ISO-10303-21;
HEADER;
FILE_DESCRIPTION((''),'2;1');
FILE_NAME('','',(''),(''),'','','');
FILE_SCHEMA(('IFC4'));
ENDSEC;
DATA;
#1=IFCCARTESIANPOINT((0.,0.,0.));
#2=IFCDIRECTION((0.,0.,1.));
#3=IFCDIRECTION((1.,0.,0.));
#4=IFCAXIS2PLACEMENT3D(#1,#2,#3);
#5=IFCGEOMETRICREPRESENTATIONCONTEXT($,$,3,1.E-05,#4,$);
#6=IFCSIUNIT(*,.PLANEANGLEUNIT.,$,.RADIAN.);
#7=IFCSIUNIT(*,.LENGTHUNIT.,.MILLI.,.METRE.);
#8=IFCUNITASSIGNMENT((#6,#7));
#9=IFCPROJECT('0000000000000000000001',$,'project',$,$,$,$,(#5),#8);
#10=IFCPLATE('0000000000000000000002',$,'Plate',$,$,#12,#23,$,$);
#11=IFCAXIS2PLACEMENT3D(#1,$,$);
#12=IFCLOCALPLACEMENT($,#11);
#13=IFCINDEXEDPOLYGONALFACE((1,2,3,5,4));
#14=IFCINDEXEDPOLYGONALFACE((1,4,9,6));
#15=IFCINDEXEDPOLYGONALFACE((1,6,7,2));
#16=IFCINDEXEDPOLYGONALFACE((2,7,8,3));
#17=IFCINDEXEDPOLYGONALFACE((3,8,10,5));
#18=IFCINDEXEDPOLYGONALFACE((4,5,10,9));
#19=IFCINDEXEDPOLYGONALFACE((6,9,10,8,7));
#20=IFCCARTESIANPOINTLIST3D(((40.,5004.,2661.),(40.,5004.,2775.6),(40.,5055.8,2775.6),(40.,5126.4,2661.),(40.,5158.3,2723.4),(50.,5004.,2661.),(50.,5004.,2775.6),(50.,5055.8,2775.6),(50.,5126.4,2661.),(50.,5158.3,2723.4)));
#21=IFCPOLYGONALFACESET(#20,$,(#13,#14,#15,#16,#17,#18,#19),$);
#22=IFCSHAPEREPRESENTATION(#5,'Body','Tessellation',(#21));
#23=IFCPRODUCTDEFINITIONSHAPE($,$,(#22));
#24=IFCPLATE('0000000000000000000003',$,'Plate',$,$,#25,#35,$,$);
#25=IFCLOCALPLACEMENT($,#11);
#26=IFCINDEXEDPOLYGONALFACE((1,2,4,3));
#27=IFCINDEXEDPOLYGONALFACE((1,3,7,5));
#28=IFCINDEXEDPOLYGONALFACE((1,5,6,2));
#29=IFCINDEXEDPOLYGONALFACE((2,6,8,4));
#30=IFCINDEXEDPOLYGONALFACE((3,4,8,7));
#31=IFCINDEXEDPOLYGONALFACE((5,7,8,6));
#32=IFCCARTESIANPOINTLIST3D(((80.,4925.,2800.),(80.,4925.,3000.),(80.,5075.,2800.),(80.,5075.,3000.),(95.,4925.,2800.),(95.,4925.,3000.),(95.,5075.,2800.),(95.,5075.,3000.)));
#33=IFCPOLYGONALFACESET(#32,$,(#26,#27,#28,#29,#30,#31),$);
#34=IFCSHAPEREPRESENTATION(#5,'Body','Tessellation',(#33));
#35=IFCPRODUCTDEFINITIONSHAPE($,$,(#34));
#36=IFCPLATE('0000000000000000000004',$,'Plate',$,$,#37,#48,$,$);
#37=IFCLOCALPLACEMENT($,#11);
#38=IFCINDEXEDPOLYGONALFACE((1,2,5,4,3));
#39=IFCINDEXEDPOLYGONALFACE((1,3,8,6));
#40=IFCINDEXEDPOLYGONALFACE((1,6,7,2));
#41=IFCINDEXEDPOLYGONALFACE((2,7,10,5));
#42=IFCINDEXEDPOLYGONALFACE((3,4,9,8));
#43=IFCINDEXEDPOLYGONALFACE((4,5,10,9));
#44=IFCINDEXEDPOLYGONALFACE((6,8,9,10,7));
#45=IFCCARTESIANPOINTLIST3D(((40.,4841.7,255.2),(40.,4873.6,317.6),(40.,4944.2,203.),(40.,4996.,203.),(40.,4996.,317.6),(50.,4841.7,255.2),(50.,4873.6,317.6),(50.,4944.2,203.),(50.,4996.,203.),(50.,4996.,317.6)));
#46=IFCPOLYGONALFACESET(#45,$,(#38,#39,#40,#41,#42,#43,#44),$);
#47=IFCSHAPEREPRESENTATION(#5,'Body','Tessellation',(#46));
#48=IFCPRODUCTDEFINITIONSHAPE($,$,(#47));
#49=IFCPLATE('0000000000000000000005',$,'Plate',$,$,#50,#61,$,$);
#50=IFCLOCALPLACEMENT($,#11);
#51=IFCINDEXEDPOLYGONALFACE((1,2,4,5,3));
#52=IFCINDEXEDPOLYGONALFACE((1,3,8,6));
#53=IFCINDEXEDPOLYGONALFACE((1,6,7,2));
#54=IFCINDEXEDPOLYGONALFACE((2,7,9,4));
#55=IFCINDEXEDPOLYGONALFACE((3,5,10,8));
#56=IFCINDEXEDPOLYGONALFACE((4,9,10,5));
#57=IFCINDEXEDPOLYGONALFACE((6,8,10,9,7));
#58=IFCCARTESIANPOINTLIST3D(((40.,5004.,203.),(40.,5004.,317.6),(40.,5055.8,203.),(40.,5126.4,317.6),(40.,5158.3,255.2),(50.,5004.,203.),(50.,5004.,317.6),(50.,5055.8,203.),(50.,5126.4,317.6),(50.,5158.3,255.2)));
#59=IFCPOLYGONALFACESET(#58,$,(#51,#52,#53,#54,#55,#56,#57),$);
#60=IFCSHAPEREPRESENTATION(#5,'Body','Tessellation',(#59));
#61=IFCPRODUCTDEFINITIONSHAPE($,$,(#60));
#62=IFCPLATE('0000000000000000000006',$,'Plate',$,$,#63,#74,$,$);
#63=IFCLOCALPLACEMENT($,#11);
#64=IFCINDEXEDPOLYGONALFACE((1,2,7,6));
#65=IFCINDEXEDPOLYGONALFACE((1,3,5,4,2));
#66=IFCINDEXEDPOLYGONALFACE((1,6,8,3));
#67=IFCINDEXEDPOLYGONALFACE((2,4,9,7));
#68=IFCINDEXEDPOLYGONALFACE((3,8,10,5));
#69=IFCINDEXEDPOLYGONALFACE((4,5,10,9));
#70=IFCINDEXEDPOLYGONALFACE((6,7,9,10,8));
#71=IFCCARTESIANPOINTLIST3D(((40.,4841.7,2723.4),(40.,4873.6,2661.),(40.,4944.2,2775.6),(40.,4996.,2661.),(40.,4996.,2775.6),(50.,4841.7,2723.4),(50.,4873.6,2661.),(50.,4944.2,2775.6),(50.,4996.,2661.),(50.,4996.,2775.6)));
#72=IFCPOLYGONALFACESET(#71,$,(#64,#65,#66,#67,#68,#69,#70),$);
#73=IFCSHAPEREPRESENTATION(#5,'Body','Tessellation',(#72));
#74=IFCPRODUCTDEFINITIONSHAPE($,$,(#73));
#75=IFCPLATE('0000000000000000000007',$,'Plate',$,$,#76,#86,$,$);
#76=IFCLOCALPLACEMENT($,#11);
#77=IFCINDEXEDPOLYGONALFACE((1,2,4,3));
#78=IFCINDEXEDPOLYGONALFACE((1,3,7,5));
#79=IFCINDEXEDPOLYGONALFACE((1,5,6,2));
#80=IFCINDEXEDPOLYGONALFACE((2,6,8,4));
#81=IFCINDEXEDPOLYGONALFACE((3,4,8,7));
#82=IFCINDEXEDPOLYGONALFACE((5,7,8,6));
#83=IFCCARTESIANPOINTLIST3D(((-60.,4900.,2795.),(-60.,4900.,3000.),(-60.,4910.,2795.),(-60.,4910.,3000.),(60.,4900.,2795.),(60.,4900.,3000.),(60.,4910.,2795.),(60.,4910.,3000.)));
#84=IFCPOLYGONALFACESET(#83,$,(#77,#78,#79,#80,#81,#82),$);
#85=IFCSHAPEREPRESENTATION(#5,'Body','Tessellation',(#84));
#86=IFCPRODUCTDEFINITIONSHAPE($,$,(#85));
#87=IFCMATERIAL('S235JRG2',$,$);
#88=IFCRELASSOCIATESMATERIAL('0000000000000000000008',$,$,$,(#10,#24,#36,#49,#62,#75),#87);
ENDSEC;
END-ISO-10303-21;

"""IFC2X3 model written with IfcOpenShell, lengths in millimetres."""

from ifc_helpers import new_model, si_unit, frame, origin_with_axes, place, context, project, polyline, outline, extrude, material, element, save


model = new_model("IFC2X3")

# Units and contexts
context_of_model = context(None, 3, precision=1e-05, world=origin_with_axes())
ifc_project = project(units=[si_unit("PLANEANGLEUNIT", "RADIAN"), si_unit("LENGTHUNIT", "METRE", prefix="MILLI")], contexts=[context_of_model])

# Shared definitions
ifc_material = material(Name="S235JRG2")

# Plates
placement_1 = place(None, origin_with_axes())
plate_1_placement = place(placement_1, frame((40.0, 5055.8, 2775.6), z_axis=(0.0, 0.0, -1.0), x_axis=(1.0, 0.0, 0.0)))
element("IfcPlate", 1, at=plate_1_placement, material=ifc_material, Name="Plate", context=context_of_model, shape_type="SweptSolid", body=[
    extrude(outline(polyline([(0.0, 0.0), (51.8, 0.0), (51.8, 114.6), (-70.6, 114.6), (-102.4, 52.3), (0.0, 0.0)])), frame((0.0, 0.0, 0.0), z_axis=(1.0, 0.0, 0.0), x_axis=(0.0, 1.0, 0.0)), (0.0, 0.0, 1.0), 10.0),
])
placement_2 = place(None, origin_with_axes())
plate_2_placement = place(placement_2, frame((95.0, 4925.0, 2800.0), z_axis=(0.0, 1.0, 0.0), x_axis=(-1.0, 0.0, 0.0)))
element("IfcPlate", 2, at=plate_2_placement, material=ifc_material, Name="Plate", context=context_of_model, shape_type="SweptSolid", body=[
    extrude(outline(polyline([(0.0, 0.0), (200.0, 0.0), (200.0, 150.0), (0.0, 150.0), (0.0, 0.0)])), frame((0.0, 0.0, 0.0), z_axis=(1.0, 0.0, 0.0), x_axis=(0.0, 1.0, 0.0)), (0.0, 0.0, 1.0), 15.0),
])
placement_3 = place(None, origin_with_axes())
plate_3_placement = place(placement_3, frame((40.0, 4944.2, 203.0), z_axis=(0.0, 0.0, 1.0), x_axis=(1.0, 0.0, 0.0)))
element("IfcPlate", 3, at=plate_3_placement, material=ifc_material, Name="Plate", context=context_of_model, shape_type="SweptSolid", body=[
    extrude(outline(polyline([(0.0, 0.0), (51.8, 0.0), (51.8, 114.6), (-70.6, 114.6), (-102.4, 52.3), (0.0, 0.0)])), frame((0.0, 0.0, 0.0), z_axis=(1.0, 0.0, 0.0), x_axis=(0.0, 1.0, 0.0)), (0.0, 0.0, 1.0), 10.0),
])
placement_4 = place(None, origin_with_axes())
plate_4_placement = place(placement_4, frame((50.0, 5055.8, 203.0), z_axis=(0.0, 0.0, 1.0), x_axis=(-1.0, 0.0, 0.0)))
element("IfcPlate", 4, at=plate_4_placement, material=ifc_material, Name="Plate", context=context_of_model, shape_type="SweptSolid", body=[
    extrude(outline(polyline([(0.0, 0.0), (51.8, 0.0), (51.8, 114.6), (-70.6, 114.6), (-102.4, 52.3), (0.0, 0.0)])), frame((0.0, 0.0, 0.0), z_axis=(1.0, 0.0, 0.0), x_axis=(0.0, 1.0, 0.0)), (0.0, 0.0, 1.0), 10.0),
])
placement_5 = place(None, origin_with_axes())
plate_5_placement = place(placement_5, frame((50.0, 4944.2, 2775.6), z_axis=(0.0, 0.0, -1.0), x_axis=(-1.0, 0.0, 0.0)))
element("IfcPlate", 5, at=plate_5_placement, material=ifc_material, Name="Plate", context=context_of_model, shape_type="SweptSolid", body=[
    extrude(outline(polyline([(0.0, 0.0), (51.8, 0.0), (51.8, 114.6), (-70.6, 114.6), (-102.4, 52.3), (0.0, 0.0)])), frame((0.0, 0.0, 0.0), z_axis=(1.0, 0.0, 0.0), x_axis=(0.0, 1.0, 0.0)), (0.0, 0.0, 1.0), 10.0),
])
placement_6 = place(None, origin_with_axes())
plate_6_placement = place(placement_6, frame((60.0, 4900.0, 2795.0), z_axis=(0.0, 0.0, 1.0), x_axis=(0.0, 1.0, 0.0)))
element("IfcPlate", 6, at=plate_6_placement, material=ifc_material, Name="Plate", context=context_of_model, shape_type="SweptSolid", body=[
    extrude(outline(polyline([(0.0, 0.0), (120.0, 0.0), (120.0, 205.0), (0.0, 205.0), (0.0, 0.0)])), frame((0.0, 0.0, 0.0), z_axis=(1.0, 0.0, 0.0), x_axis=(0.0, 1.0, 0.0)), (0.0, 0.0, 1.0), 10.0),
])

save(model, "model.ifc")
